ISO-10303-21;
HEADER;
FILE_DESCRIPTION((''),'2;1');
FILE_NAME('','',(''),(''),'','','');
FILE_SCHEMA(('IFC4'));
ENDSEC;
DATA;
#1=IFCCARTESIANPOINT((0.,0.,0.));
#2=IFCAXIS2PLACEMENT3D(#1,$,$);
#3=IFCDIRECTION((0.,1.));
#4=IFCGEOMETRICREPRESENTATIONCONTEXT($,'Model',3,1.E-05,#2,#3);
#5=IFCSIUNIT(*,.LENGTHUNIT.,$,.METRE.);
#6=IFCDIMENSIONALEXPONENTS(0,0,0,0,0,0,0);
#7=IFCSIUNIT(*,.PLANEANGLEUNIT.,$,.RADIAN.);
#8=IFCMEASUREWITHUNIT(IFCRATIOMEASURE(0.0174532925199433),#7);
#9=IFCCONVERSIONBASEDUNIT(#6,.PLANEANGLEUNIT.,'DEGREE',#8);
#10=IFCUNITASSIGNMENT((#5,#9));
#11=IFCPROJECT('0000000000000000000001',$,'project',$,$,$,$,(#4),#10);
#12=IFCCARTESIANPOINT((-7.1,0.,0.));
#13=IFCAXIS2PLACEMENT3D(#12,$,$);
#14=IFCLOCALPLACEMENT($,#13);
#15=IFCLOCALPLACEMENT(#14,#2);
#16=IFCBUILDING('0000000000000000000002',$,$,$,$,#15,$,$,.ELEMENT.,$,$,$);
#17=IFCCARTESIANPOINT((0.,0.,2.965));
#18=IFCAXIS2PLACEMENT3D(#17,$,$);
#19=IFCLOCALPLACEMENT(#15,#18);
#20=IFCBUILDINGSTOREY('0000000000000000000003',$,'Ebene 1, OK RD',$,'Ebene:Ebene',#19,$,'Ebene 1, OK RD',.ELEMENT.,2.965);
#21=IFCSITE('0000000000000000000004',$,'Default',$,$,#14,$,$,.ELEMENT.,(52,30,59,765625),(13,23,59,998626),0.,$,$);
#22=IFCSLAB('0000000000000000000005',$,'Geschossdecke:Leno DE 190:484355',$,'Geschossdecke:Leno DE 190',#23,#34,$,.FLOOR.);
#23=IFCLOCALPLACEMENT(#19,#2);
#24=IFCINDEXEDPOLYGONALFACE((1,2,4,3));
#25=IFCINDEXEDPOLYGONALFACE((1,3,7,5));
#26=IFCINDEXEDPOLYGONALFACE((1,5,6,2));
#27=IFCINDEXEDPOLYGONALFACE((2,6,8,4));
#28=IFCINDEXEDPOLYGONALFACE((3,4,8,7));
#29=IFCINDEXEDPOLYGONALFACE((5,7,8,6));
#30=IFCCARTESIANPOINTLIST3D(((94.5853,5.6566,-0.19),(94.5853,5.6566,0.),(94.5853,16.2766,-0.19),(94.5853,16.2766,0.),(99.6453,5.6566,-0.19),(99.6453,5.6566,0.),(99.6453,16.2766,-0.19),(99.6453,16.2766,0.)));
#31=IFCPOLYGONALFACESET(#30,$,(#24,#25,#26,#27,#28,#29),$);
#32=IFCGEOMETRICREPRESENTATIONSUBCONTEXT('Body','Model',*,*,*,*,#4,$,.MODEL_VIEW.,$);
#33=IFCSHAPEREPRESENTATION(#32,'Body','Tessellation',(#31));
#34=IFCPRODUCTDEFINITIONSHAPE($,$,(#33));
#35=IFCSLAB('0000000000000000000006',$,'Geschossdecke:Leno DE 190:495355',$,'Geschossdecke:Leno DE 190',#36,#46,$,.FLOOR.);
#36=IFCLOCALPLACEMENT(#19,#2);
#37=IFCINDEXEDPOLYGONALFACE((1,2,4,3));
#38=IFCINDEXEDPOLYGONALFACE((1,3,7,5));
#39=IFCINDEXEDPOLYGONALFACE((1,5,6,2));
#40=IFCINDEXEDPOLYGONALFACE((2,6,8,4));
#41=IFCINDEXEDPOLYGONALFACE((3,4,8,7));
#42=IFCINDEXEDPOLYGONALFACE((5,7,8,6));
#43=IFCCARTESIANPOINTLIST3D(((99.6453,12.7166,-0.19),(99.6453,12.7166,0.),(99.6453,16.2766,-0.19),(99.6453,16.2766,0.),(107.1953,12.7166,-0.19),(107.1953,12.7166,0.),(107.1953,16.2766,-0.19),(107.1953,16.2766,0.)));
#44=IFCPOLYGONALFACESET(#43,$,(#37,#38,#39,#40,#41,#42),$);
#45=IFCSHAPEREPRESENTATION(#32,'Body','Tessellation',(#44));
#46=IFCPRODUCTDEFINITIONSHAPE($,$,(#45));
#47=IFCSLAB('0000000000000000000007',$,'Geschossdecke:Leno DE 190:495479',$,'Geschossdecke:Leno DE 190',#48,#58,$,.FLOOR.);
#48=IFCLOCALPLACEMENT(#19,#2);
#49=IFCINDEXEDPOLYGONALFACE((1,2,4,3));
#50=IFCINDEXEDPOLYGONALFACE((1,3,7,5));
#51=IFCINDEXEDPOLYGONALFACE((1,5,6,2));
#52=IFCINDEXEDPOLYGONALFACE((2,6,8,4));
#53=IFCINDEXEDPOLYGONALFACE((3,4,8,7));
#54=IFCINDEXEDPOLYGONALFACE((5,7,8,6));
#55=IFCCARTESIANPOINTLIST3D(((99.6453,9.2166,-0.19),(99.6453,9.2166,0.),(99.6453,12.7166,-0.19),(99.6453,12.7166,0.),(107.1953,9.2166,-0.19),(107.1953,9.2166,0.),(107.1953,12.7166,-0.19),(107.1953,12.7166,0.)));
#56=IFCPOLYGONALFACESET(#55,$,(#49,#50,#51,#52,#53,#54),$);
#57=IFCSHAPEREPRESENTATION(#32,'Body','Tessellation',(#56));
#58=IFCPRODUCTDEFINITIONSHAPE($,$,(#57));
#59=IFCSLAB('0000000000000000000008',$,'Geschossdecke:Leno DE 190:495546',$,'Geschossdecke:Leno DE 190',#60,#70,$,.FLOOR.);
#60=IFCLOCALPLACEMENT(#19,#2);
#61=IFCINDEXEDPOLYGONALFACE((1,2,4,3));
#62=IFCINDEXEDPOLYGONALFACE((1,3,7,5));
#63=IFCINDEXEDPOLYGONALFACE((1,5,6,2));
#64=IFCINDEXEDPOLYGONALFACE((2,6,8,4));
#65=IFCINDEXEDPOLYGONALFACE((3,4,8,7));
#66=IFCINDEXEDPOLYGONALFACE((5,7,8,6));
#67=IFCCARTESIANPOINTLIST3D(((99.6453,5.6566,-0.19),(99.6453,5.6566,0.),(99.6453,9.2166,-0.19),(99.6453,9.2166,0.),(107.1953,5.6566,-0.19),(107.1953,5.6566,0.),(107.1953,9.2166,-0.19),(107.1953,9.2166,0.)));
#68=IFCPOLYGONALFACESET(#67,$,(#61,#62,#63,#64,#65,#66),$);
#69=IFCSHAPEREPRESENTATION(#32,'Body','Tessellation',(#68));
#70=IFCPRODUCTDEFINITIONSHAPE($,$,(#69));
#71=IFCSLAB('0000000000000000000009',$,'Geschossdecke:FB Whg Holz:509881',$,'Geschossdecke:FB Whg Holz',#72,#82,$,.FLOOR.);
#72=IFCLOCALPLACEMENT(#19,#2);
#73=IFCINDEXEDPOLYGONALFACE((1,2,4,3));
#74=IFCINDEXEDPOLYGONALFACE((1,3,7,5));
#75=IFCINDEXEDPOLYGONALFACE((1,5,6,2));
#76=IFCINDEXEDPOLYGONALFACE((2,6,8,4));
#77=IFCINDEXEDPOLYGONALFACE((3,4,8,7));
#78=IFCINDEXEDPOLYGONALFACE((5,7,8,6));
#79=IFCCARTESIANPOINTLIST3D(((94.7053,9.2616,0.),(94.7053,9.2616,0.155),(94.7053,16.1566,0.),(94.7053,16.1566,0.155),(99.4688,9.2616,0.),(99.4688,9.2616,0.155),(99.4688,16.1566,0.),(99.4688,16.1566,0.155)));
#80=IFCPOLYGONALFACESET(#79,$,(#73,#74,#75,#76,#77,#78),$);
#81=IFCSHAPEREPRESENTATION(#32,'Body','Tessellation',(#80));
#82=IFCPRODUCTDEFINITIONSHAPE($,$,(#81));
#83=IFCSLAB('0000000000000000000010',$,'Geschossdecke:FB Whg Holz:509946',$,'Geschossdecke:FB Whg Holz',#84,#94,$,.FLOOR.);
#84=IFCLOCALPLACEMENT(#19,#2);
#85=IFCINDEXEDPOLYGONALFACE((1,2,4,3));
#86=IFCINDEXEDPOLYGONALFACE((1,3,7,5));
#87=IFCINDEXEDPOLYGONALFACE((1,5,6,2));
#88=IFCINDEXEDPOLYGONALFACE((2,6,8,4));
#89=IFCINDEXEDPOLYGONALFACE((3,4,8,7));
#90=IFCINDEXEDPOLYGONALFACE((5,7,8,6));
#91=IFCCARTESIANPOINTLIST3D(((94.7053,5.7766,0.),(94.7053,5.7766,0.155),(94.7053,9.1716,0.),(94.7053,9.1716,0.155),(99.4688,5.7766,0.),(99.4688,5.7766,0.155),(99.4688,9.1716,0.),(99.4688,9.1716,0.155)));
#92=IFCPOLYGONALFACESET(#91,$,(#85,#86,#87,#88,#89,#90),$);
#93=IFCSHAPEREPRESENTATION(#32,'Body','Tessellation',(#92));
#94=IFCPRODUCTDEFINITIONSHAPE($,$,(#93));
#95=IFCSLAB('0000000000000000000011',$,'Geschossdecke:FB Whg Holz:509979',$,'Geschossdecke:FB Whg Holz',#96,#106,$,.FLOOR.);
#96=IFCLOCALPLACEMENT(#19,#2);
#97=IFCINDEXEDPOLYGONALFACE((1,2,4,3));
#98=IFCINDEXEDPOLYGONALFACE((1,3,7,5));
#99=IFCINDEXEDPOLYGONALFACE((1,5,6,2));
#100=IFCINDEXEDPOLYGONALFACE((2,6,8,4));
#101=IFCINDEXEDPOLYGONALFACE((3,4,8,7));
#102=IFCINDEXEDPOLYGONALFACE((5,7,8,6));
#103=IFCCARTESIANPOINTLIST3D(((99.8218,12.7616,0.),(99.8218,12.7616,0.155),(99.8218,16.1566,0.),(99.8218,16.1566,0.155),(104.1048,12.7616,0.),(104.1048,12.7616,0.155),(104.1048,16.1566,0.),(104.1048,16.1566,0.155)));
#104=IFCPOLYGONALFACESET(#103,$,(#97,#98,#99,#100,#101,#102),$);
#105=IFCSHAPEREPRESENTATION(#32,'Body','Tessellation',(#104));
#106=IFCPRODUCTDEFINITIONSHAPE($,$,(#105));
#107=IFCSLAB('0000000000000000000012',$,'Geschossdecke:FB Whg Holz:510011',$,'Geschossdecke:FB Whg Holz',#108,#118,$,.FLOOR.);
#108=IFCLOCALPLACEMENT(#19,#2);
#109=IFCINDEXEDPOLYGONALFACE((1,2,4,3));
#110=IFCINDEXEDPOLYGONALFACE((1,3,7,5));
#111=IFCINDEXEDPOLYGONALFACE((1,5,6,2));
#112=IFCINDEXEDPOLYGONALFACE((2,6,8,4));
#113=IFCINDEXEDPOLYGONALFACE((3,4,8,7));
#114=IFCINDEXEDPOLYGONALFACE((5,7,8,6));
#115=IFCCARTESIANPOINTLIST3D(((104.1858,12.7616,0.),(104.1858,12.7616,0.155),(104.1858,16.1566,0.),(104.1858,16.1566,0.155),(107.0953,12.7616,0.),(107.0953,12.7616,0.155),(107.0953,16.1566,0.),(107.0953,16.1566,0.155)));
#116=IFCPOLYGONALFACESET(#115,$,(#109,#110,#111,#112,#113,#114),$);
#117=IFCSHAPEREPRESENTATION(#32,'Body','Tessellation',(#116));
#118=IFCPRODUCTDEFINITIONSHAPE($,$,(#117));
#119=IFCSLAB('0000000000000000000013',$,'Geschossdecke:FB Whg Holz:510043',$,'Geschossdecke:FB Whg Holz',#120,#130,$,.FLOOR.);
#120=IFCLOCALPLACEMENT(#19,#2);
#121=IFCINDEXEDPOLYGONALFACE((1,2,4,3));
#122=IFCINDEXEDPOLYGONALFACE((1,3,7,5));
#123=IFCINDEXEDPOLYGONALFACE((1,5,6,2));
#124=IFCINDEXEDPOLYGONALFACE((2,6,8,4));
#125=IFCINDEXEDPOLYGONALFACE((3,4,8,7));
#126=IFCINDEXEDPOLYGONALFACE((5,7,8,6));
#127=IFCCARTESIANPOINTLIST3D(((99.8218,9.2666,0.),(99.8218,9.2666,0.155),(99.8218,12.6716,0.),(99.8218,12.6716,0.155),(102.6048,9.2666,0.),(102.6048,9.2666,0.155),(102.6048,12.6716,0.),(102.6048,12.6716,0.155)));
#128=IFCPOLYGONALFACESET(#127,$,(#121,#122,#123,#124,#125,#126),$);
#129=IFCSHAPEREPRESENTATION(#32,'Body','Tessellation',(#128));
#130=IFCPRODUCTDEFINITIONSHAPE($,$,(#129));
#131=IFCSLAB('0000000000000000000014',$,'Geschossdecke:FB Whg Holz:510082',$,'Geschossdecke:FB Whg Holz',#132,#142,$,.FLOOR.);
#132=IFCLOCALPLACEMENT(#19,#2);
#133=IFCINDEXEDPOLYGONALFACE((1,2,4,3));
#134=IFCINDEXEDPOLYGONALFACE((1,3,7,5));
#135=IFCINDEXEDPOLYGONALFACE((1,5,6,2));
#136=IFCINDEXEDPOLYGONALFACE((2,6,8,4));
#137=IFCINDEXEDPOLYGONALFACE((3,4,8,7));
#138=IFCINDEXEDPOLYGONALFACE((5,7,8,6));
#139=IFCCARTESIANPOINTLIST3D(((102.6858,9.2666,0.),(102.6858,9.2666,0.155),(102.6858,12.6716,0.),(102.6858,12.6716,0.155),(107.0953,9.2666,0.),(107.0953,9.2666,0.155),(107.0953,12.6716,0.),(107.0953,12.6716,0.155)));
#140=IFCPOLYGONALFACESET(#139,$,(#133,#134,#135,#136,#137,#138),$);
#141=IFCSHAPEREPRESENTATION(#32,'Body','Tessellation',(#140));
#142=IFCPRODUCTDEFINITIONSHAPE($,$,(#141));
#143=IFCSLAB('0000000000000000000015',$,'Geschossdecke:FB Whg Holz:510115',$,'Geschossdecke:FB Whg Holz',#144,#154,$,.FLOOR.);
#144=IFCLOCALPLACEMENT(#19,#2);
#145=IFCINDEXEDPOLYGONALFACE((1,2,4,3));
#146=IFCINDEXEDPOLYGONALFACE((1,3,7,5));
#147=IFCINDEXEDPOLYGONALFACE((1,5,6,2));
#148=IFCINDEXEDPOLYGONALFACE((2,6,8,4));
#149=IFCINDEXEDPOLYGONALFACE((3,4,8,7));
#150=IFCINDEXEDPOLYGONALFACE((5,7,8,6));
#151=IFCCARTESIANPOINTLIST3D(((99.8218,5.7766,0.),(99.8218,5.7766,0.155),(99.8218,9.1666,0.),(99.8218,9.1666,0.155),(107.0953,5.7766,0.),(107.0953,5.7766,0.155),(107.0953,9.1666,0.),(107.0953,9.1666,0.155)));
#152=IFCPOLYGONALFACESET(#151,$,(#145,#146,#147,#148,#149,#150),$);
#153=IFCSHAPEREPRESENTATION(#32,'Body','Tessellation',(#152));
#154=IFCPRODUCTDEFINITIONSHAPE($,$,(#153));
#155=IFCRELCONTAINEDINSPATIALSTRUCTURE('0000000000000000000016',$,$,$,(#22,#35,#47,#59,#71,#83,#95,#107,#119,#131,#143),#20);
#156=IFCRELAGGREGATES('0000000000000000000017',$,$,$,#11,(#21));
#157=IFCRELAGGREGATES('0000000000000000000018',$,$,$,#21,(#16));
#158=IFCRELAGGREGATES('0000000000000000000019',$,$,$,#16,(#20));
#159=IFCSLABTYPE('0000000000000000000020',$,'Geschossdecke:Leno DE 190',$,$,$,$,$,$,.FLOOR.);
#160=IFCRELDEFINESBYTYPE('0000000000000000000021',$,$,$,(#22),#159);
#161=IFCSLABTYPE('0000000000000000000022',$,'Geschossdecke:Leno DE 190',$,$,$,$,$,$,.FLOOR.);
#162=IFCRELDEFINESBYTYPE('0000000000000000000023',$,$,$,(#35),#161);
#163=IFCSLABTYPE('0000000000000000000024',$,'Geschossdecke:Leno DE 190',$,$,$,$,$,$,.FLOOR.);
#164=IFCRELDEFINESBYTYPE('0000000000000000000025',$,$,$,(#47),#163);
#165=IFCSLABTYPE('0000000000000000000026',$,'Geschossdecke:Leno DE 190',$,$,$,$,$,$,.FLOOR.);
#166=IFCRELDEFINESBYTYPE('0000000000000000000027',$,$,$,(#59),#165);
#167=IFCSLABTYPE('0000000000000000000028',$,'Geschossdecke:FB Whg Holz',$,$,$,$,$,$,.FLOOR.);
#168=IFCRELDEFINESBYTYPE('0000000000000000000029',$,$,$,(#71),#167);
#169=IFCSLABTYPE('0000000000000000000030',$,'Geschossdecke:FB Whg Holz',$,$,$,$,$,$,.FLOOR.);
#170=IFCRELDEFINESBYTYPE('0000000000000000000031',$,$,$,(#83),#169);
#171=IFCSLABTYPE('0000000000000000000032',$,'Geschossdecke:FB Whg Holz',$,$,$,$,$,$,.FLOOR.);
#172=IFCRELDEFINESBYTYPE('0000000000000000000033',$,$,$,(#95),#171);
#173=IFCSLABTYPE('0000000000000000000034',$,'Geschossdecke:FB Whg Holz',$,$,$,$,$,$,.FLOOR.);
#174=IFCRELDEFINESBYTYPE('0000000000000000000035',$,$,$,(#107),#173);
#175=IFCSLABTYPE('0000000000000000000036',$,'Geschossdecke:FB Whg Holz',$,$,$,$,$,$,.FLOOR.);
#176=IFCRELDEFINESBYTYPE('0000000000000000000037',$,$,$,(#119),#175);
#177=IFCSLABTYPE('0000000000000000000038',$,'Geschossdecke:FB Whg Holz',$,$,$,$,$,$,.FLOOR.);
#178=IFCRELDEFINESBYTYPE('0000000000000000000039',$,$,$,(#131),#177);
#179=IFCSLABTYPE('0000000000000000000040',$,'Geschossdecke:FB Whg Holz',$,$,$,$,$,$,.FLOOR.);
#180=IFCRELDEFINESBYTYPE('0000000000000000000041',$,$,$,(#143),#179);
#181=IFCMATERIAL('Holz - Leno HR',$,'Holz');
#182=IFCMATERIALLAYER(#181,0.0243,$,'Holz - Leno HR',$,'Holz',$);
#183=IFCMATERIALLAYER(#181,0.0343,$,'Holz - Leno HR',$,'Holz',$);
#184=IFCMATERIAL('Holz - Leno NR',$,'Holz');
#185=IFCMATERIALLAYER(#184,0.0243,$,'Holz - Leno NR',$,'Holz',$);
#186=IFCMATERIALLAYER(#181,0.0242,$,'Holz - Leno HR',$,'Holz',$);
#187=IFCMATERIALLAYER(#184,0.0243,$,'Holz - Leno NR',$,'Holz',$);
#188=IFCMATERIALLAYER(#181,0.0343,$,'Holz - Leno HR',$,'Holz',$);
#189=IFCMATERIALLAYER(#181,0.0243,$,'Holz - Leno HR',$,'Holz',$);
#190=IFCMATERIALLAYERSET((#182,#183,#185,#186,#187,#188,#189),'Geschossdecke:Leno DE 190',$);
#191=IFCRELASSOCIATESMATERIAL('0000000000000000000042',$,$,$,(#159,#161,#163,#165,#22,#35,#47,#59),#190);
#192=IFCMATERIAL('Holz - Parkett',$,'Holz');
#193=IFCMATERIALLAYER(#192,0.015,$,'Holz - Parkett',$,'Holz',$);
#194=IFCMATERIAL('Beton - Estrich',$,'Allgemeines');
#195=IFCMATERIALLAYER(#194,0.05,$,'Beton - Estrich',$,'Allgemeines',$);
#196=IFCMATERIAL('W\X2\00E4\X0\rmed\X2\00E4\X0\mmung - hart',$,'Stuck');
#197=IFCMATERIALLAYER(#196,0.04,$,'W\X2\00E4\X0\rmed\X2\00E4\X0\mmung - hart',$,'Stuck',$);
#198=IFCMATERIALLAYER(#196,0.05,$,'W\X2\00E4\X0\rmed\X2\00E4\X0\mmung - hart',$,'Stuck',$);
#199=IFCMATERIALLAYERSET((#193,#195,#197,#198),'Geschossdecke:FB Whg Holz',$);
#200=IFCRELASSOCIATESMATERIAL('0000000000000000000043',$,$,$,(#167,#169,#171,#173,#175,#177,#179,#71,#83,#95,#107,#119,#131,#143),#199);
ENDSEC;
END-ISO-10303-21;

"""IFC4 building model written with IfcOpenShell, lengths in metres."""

from ifc_helpers import new_model, entity, si_unit, converted_unit, direction, frame, frame_2d, origin, origin_2d_with_axis, place, context, subcontext, project, spatial, rectangle, extrude, material, layer, layer_set, layer_usage, type_object, element, save


model = new_model("IFC4")

# Units and contexts
model_context = context("Model", 3, precision=1e-05, world=origin(), true_north=direction((0.0, 1.0)))
body_context = subcontext(model_context, "Body", "Model", "MODEL_VIEW")
ifc_project = project(units=[si_unit("LENGTHUNIT", "METRE"), converted_unit("PLANEANGLEUNIT", "DEGREE", entity("IfcRatioMeasure", 0.0174532925199433), si_unit("PLANEANGLEUNIT", "RADIAN"), dimensions=[0, 0, 0, 0, 0, 0, 0])], contexts=[model_context])

# Site, building, storey
site_placement = place(None, frame((-7.1, 0.0, 0.0)))
site = spatial("IfcSite", under=ifc_project, at=site_placement, Name="Default", CompositionType="ELEMENT", RefLatitude=(52, 30, 59, 765625), RefLongitude=(13, 23, 59, 998626), RefElevation=0.0)
building_placement = place(site_placement, origin())
building = spatial("IfcBuilding", under=site, at=building_placement, CompositionType="ELEMENT")
storey_placement = place(building_placement, frame((0.0, 0.0, 2.965)))
storey = spatial("IfcBuildingStorey", under=building, at=storey_placement, Name="Ebene 1, OK RD", ObjectType="Ebene:Ebene", LongName="Ebene 1, OK RD", CompositionType="ELEMENT", Elevation=2.965)

# Slabs
ifc_material_1 = material(Name="Holz - Leno HR", Category="Holz")
ifc_layer_1 = layer(ifc_material_1, 0.0243, Name="Holz - Leno HR", Category="Holz")
ifc_layer_2 = layer(ifc_material_1, 0.0343, Name="Holz - Leno HR", Category="Holz")
ifc_material_2 = material(Name="Holz - Leno NR", Category="Holz")
ifc_layer_3 = layer(ifc_material_2, 0.0243, Name="Holz - Leno NR", Category="Holz")
ifc_layer_4 = layer(ifc_material_1, 0.0242, Name="Holz - Leno HR", Category="Holz")
ifc_layer_5 = layer(ifc_material_2, 0.0243, Name="Holz - Leno NR", Category="Holz")
ifc_layer_6 = layer(ifc_material_1, 0.0343, Name="Holz - Leno HR", Category="Holz")
ifc_layer_7 = layer(ifc_material_1, 0.0243, Name="Holz - Leno HR", Category="Holz")
ifc_layer_set_1 = layer_set([ifc_layer_1, ifc_layer_2, ifc_layer_3, ifc_layer_4, ifc_layer_5, ifc_layer_6, ifc_layer_7], Name="Geschossdecke:Leno DE 190")
ifc_layer_usage_1 = layer_usage(ifc_layer_set_1, "AXIS3", "POSITIVE", 0.0)
slab_type_1 = type_object("IfcSlabType", Name="Geschossdecke:Leno DE 190", PredefinedType="FLOOR", material=ifc_layer_set_1)
slab_1_placement = place(storey_placement, origin())
element("IfcSlab", 1, at=slab_1_placement, inside=storey, type_object=slab_type_1, material=ifc_layer_usage_1, Name="Geschossdecke:Leno DE 190:484355", ObjectType="Geschossdecke:Leno DE 190", PredefinedType="FLOOR", context=body_context, shape_type="SweptSolid", body=[
    extrude(rectangle(XDim=10.62, YDim=5.06, at=frame_2d((0.0, 0.0), x_axis=(1.0, 0.0))), frame((97.1153, 10.9666, 0.0), z_axis=(0.0, 0.0, -1.0), x_axis=(0.0, 1.0, 0.0)), (0.0, 0.0, 1.0), 0.19),
])
ifc_layer_usage_2 = layer_usage(ifc_layer_set_1, "AXIS3", "POSITIVE", 0.0)
slab_type_2 = type_object("IfcSlabType", Name="Geschossdecke:Leno DE 190", PredefinedType="FLOOR", material=ifc_layer_set_1)
slab_2_placement = place(storey_placement, origin())
element("IfcSlab", 2, at=slab_2_placement, inside=storey, type_object=slab_type_2, material=ifc_layer_usage_2, Name="Geschossdecke:Leno DE 190:495355", ObjectType="Geschossdecke:Leno DE 190", PredefinedType="FLOOR", context=body_context, shape_type="SweptSolid", body=[
    extrude(rectangle(XDim=3.56, YDim=7.55, at=frame_2d((0.0, 0.0), x_axis=(1.0, 0.0))), frame((103.4203, 14.4966, 0.0), z_axis=(0.0, 0.0, -1.0), x_axis=(0.0, 1.0, 0.0)), (0.0, 0.0, 1.0), 0.19),
])
ifc_layer_usage_3 = layer_usage(ifc_layer_set_1, "AXIS3", "POSITIVE", 0.0)
slab_type_3 = type_object("IfcSlabType", Name="Geschossdecke:Leno DE 190", PredefinedType="FLOOR", material=ifc_layer_set_1)
slab_3_placement = place(storey_placement, origin())
element("IfcSlab", 3, at=slab_3_placement, inside=storey, type_object=slab_type_3, material=ifc_layer_usage_3, Name="Geschossdecke:Leno DE 190:495479", ObjectType="Geschossdecke:Leno DE 190", PredefinedType="FLOOR", context=body_context, shape_type="SweptSolid", body=[
    extrude(rectangle(XDim=3.5, YDim=7.55, at=frame_2d((0.0, 0.0), x_axis=(1.0, 0.0))), frame((103.4203, 10.9666, 0.0), z_axis=(0.0, 0.0, -1.0), x_axis=(0.0, 1.0, 0.0)), (0.0, 0.0, 1.0), 0.19),
])
ifc_layer_usage_4 = layer_usage(ifc_layer_set_1, "AXIS3", "POSITIVE", 0.0)
slab_type_4 = type_object("IfcSlabType", Name="Geschossdecke:Leno DE 190", PredefinedType="FLOOR", material=ifc_layer_set_1)
slab_4_placement = place(storey_placement, origin())
element("IfcSlab", 4, at=slab_4_placement, inside=storey, type_object=slab_type_4, material=ifc_layer_usage_4, Name="Geschossdecke:Leno DE 190:495546", ObjectType="Geschossdecke:Leno DE 190", PredefinedType="FLOOR", context=body_context, shape_type="SweptSolid", body=[
    extrude(rectangle(XDim=3.56, YDim=7.55, at=frame_2d((0.0, 0.0), x_axis=(1.0, 0.0))), frame((103.4203, 7.4366, 0.0), z_axis=(0.0, 0.0, -1.0), x_axis=(0.0, 1.0, 0.0)), (0.0, 0.0, 1.0), 0.19),
])
ifc_material_3 = material(Name="Holz - Parkett", Category="Holz")
ifc_layer_8 = layer(ifc_material_3, 0.015, Name="Holz - Parkett", Category="Holz")
ifc_material_4 = material(Name="Beton - Estrich", Category="Allgemeines")
ifc_layer_9 = layer(ifc_material_4, 0.05, Name="Beton - Estrich", Category="Allgemeines")
ifc_material_5 = material(Name="Wärmedämmung - hart", Category="Stuck")
ifc_layer_10 = layer(ifc_material_5, 0.04, Name="Wärmedämmung - hart", Category="Stuck")
ifc_layer_11 = layer(ifc_material_5, 0.05, Name="Wärmedämmung - hart", Category="Stuck")
ifc_layer_set_2 = layer_set([ifc_layer_8, ifc_layer_9, ifc_layer_10, ifc_layer_11], Name="Geschossdecke:FB Whg Holz")
ifc_layer_usage_5 = layer_usage(ifc_layer_set_2, "AXIS3", "POSITIVE", 0.0)
slab_type_5 = type_object("IfcSlabType", Name="Geschossdecke:FB Whg Holz", PredefinedType="FLOOR", material=ifc_layer_set_2)
slab_5_placement = place(storey_placement, origin())
element("IfcSlab", 5, at=slab_5_placement, inside=storey, type_object=slab_type_5, material=ifc_layer_usage_5, Name="Geschossdecke:FB Whg Holz:509881", ObjectType="Geschossdecke:FB Whg Holz", PredefinedType="FLOOR", context=body_context, shape_type="SweptSolid", body=[
    extrude(rectangle(XDim=6.895, YDim=4.7635, at=frame_2d((0.0, 0.0), x_axis=(1.0, 0.0))), frame((97.0871, 12.7091, 0.155), z_axis=(0.0, 0.0, -1.0), x_axis=(0.0, 1.0, 0.0)), (0.0, 0.0, 1.0), 0.155),
])
ifc_layer_usage_6 = layer_usage(ifc_layer_set_2, "AXIS3", "POSITIVE", 0.0)
slab_type_6 = type_object("IfcSlabType", Name="Geschossdecke:FB Whg Holz", PredefinedType="FLOOR", material=ifc_layer_set_2)
slab_6_placement = place(storey_placement, origin())
element("IfcSlab", 6, at=slab_6_placement, inside=storey, type_object=slab_type_6, material=ifc_layer_usage_6, Name="Geschossdecke:FB Whg Holz:509946", ObjectType="Geschossdecke:FB Whg Holz", PredefinedType="FLOOR", context=body_context, shape_type="SweptSolid", body=[
    extrude(rectangle(XDim=3.395, YDim=4.7635, at=origin_2d_with_axis()), frame((97.0871, 7.4741, 0.155), z_axis=(0.0, 0.0, -1.0), x_axis=(0.0, 1.0, 0.0)), (0.0, 0.0, 1.0), 0.155),
])
ifc_layer_usage_7 = layer_usage(ifc_layer_set_2, "AXIS3", "POSITIVE", 0.0)
slab_type_7 = type_object("IfcSlabType", Name="Geschossdecke:FB Whg Holz", PredefinedType="FLOOR", material=ifc_layer_set_2)
slab_7_placement = place(storey_placement, origin())
element("IfcSlab", 7, at=slab_7_placement, inside=storey, type_object=slab_type_7, material=ifc_layer_usage_7, Name="Geschossdecke:FB Whg Holz:509979", ObjectType="Geschossdecke:FB Whg Holz", PredefinedType="FLOOR", context=body_context, shape_type="SweptSolid", body=[
    extrude(rectangle(XDim=3.395, YDim=4.283, at=frame_2d((0.0, 0.0), x_axis=(1.0, 0.0))), frame((101.9633, 14.4591, 0.155), z_axis=(0.0, 0.0, -1.0), x_axis=(0.0, 1.0, 0.0)), (0.0, 0.0, 1.0), 0.155),
])
ifc_layer_usage_8 = layer_usage(ifc_layer_set_2, "AXIS3", "POSITIVE", 0.0)
slab_type_8 = type_object("IfcSlabType", Name="Geschossdecke:FB Whg Holz", PredefinedType="FLOOR", material=ifc_layer_set_2)
slab_8_placement = place(storey_placement, origin())
element("IfcSlab", 8, at=slab_8_placement, inside=storey, type_object=slab_type_8, material=ifc_layer_usage_8, Name="Geschossdecke:FB Whg Holz:510011", ObjectType="Geschossdecke:FB Whg Holz", PredefinedType="FLOOR", context=body_context, shape_type="SweptSolid", body=[
    extrude(rectangle(XDim=3.395, YDim=2.9095, at=frame_2d((0.0, 0.0), x_axis=(1.0, 0.0))), frame((105.6406, 14.4591, 0.155), z_axis=(0.0, 0.0, -1.0), x_axis=(0.0, 1.0, 0.0)), (0.0, 0.0, 1.0), 0.155),
])
ifc_layer_usage_9 = layer_usage(ifc_layer_set_2, "AXIS3", "POSITIVE", 0.0)
slab_type_9 = type_object("IfcSlabType", Name="Geschossdecke:FB Whg Holz", PredefinedType="FLOOR", material=ifc_layer_set_2)
slab_9_placement = place(storey_placement, origin())
element("IfcSlab", 9, at=slab_9_placement, inside=storey, type_object=slab_type_9, material=ifc_layer_usage_9, Name="Geschossdecke:FB Whg Holz:510043", ObjectType="Geschossdecke:FB Whg Holz", PredefinedType="FLOOR", context=body_context, shape_type="SweptSolid", body=[
    extrude(rectangle(XDim=3.405, YDim=2.783, at=frame_2d((0.0, 0.0), x_axis=(1.0, 0.0))), frame((101.2133, 10.9691, 0.155), z_axis=(0.0, 0.0, -1.0), x_axis=(0.0, 1.0, 0.0)), (0.0, 0.0, 1.0), 0.155),
])
ifc_layer_usage_10 = layer_usage(ifc_layer_set_2, "AXIS3", "POSITIVE", 0.0)
slab_type_10 = type_object("IfcSlabType", Name="Geschossdecke:FB Whg Holz", PredefinedType="FLOOR", material=ifc_layer_set_2)
slab_10_placement = place(storey_placement, origin())
element("IfcSlab", 10, at=slab_10_placement, inside=storey, type_object=slab_type_10, material=ifc_layer_usage_10, Name="Geschossdecke:FB Whg Holz:510082", ObjectType="Geschossdecke:FB Whg Holz", PredefinedType="FLOOR", context=body_context, shape_type="SweptSolid", body=[
    extrude(rectangle(XDim=3.405, YDim=4.4095, at=frame_2d((0.0, 0.0), x_axis=(1.0, 0.0))), frame((104.8906, 10.9691, 0.155), z_axis=(0.0, 0.0, -1.0), x_axis=(0.0, 1.0, 0.0)), (0.0, 0.0, 1.0), 0.155),
])
ifc_layer_usage_11 = layer_usage(ifc_layer_set_2, "AXIS3", "POSITIVE", 0.0)
slab_type_11 = type_object("IfcSlabType", Name="Geschossdecke:FB Whg Holz", PredefinedType="FLOOR", material=ifc_layer_set_2)
slab_11_placement = place(storey_placement, origin())
element("IfcSlab", 11, at=slab_11_placement, inside=storey, type_object=slab_type_11, material=ifc_layer_usage_11, Name="Geschossdecke:FB Whg Holz:510115", ObjectType="Geschossdecke:FB Whg Holz", PredefinedType="FLOOR", context=body_context, shape_type="SweptSolid", body=[
    extrude(rectangle(XDim=3.39, YDim=7.2735, at=frame_2d((0.0, 0.0), x_axis=(1.0, 0.0))), frame((103.4586, 7.4716, 0.155), z_axis=(0.0, 0.0, -1.0), x_axis=(0.0, 1.0, 0.0)), (0.0, 0.0, 1.0), 0.155),
])

save(model, "model.ifc")
